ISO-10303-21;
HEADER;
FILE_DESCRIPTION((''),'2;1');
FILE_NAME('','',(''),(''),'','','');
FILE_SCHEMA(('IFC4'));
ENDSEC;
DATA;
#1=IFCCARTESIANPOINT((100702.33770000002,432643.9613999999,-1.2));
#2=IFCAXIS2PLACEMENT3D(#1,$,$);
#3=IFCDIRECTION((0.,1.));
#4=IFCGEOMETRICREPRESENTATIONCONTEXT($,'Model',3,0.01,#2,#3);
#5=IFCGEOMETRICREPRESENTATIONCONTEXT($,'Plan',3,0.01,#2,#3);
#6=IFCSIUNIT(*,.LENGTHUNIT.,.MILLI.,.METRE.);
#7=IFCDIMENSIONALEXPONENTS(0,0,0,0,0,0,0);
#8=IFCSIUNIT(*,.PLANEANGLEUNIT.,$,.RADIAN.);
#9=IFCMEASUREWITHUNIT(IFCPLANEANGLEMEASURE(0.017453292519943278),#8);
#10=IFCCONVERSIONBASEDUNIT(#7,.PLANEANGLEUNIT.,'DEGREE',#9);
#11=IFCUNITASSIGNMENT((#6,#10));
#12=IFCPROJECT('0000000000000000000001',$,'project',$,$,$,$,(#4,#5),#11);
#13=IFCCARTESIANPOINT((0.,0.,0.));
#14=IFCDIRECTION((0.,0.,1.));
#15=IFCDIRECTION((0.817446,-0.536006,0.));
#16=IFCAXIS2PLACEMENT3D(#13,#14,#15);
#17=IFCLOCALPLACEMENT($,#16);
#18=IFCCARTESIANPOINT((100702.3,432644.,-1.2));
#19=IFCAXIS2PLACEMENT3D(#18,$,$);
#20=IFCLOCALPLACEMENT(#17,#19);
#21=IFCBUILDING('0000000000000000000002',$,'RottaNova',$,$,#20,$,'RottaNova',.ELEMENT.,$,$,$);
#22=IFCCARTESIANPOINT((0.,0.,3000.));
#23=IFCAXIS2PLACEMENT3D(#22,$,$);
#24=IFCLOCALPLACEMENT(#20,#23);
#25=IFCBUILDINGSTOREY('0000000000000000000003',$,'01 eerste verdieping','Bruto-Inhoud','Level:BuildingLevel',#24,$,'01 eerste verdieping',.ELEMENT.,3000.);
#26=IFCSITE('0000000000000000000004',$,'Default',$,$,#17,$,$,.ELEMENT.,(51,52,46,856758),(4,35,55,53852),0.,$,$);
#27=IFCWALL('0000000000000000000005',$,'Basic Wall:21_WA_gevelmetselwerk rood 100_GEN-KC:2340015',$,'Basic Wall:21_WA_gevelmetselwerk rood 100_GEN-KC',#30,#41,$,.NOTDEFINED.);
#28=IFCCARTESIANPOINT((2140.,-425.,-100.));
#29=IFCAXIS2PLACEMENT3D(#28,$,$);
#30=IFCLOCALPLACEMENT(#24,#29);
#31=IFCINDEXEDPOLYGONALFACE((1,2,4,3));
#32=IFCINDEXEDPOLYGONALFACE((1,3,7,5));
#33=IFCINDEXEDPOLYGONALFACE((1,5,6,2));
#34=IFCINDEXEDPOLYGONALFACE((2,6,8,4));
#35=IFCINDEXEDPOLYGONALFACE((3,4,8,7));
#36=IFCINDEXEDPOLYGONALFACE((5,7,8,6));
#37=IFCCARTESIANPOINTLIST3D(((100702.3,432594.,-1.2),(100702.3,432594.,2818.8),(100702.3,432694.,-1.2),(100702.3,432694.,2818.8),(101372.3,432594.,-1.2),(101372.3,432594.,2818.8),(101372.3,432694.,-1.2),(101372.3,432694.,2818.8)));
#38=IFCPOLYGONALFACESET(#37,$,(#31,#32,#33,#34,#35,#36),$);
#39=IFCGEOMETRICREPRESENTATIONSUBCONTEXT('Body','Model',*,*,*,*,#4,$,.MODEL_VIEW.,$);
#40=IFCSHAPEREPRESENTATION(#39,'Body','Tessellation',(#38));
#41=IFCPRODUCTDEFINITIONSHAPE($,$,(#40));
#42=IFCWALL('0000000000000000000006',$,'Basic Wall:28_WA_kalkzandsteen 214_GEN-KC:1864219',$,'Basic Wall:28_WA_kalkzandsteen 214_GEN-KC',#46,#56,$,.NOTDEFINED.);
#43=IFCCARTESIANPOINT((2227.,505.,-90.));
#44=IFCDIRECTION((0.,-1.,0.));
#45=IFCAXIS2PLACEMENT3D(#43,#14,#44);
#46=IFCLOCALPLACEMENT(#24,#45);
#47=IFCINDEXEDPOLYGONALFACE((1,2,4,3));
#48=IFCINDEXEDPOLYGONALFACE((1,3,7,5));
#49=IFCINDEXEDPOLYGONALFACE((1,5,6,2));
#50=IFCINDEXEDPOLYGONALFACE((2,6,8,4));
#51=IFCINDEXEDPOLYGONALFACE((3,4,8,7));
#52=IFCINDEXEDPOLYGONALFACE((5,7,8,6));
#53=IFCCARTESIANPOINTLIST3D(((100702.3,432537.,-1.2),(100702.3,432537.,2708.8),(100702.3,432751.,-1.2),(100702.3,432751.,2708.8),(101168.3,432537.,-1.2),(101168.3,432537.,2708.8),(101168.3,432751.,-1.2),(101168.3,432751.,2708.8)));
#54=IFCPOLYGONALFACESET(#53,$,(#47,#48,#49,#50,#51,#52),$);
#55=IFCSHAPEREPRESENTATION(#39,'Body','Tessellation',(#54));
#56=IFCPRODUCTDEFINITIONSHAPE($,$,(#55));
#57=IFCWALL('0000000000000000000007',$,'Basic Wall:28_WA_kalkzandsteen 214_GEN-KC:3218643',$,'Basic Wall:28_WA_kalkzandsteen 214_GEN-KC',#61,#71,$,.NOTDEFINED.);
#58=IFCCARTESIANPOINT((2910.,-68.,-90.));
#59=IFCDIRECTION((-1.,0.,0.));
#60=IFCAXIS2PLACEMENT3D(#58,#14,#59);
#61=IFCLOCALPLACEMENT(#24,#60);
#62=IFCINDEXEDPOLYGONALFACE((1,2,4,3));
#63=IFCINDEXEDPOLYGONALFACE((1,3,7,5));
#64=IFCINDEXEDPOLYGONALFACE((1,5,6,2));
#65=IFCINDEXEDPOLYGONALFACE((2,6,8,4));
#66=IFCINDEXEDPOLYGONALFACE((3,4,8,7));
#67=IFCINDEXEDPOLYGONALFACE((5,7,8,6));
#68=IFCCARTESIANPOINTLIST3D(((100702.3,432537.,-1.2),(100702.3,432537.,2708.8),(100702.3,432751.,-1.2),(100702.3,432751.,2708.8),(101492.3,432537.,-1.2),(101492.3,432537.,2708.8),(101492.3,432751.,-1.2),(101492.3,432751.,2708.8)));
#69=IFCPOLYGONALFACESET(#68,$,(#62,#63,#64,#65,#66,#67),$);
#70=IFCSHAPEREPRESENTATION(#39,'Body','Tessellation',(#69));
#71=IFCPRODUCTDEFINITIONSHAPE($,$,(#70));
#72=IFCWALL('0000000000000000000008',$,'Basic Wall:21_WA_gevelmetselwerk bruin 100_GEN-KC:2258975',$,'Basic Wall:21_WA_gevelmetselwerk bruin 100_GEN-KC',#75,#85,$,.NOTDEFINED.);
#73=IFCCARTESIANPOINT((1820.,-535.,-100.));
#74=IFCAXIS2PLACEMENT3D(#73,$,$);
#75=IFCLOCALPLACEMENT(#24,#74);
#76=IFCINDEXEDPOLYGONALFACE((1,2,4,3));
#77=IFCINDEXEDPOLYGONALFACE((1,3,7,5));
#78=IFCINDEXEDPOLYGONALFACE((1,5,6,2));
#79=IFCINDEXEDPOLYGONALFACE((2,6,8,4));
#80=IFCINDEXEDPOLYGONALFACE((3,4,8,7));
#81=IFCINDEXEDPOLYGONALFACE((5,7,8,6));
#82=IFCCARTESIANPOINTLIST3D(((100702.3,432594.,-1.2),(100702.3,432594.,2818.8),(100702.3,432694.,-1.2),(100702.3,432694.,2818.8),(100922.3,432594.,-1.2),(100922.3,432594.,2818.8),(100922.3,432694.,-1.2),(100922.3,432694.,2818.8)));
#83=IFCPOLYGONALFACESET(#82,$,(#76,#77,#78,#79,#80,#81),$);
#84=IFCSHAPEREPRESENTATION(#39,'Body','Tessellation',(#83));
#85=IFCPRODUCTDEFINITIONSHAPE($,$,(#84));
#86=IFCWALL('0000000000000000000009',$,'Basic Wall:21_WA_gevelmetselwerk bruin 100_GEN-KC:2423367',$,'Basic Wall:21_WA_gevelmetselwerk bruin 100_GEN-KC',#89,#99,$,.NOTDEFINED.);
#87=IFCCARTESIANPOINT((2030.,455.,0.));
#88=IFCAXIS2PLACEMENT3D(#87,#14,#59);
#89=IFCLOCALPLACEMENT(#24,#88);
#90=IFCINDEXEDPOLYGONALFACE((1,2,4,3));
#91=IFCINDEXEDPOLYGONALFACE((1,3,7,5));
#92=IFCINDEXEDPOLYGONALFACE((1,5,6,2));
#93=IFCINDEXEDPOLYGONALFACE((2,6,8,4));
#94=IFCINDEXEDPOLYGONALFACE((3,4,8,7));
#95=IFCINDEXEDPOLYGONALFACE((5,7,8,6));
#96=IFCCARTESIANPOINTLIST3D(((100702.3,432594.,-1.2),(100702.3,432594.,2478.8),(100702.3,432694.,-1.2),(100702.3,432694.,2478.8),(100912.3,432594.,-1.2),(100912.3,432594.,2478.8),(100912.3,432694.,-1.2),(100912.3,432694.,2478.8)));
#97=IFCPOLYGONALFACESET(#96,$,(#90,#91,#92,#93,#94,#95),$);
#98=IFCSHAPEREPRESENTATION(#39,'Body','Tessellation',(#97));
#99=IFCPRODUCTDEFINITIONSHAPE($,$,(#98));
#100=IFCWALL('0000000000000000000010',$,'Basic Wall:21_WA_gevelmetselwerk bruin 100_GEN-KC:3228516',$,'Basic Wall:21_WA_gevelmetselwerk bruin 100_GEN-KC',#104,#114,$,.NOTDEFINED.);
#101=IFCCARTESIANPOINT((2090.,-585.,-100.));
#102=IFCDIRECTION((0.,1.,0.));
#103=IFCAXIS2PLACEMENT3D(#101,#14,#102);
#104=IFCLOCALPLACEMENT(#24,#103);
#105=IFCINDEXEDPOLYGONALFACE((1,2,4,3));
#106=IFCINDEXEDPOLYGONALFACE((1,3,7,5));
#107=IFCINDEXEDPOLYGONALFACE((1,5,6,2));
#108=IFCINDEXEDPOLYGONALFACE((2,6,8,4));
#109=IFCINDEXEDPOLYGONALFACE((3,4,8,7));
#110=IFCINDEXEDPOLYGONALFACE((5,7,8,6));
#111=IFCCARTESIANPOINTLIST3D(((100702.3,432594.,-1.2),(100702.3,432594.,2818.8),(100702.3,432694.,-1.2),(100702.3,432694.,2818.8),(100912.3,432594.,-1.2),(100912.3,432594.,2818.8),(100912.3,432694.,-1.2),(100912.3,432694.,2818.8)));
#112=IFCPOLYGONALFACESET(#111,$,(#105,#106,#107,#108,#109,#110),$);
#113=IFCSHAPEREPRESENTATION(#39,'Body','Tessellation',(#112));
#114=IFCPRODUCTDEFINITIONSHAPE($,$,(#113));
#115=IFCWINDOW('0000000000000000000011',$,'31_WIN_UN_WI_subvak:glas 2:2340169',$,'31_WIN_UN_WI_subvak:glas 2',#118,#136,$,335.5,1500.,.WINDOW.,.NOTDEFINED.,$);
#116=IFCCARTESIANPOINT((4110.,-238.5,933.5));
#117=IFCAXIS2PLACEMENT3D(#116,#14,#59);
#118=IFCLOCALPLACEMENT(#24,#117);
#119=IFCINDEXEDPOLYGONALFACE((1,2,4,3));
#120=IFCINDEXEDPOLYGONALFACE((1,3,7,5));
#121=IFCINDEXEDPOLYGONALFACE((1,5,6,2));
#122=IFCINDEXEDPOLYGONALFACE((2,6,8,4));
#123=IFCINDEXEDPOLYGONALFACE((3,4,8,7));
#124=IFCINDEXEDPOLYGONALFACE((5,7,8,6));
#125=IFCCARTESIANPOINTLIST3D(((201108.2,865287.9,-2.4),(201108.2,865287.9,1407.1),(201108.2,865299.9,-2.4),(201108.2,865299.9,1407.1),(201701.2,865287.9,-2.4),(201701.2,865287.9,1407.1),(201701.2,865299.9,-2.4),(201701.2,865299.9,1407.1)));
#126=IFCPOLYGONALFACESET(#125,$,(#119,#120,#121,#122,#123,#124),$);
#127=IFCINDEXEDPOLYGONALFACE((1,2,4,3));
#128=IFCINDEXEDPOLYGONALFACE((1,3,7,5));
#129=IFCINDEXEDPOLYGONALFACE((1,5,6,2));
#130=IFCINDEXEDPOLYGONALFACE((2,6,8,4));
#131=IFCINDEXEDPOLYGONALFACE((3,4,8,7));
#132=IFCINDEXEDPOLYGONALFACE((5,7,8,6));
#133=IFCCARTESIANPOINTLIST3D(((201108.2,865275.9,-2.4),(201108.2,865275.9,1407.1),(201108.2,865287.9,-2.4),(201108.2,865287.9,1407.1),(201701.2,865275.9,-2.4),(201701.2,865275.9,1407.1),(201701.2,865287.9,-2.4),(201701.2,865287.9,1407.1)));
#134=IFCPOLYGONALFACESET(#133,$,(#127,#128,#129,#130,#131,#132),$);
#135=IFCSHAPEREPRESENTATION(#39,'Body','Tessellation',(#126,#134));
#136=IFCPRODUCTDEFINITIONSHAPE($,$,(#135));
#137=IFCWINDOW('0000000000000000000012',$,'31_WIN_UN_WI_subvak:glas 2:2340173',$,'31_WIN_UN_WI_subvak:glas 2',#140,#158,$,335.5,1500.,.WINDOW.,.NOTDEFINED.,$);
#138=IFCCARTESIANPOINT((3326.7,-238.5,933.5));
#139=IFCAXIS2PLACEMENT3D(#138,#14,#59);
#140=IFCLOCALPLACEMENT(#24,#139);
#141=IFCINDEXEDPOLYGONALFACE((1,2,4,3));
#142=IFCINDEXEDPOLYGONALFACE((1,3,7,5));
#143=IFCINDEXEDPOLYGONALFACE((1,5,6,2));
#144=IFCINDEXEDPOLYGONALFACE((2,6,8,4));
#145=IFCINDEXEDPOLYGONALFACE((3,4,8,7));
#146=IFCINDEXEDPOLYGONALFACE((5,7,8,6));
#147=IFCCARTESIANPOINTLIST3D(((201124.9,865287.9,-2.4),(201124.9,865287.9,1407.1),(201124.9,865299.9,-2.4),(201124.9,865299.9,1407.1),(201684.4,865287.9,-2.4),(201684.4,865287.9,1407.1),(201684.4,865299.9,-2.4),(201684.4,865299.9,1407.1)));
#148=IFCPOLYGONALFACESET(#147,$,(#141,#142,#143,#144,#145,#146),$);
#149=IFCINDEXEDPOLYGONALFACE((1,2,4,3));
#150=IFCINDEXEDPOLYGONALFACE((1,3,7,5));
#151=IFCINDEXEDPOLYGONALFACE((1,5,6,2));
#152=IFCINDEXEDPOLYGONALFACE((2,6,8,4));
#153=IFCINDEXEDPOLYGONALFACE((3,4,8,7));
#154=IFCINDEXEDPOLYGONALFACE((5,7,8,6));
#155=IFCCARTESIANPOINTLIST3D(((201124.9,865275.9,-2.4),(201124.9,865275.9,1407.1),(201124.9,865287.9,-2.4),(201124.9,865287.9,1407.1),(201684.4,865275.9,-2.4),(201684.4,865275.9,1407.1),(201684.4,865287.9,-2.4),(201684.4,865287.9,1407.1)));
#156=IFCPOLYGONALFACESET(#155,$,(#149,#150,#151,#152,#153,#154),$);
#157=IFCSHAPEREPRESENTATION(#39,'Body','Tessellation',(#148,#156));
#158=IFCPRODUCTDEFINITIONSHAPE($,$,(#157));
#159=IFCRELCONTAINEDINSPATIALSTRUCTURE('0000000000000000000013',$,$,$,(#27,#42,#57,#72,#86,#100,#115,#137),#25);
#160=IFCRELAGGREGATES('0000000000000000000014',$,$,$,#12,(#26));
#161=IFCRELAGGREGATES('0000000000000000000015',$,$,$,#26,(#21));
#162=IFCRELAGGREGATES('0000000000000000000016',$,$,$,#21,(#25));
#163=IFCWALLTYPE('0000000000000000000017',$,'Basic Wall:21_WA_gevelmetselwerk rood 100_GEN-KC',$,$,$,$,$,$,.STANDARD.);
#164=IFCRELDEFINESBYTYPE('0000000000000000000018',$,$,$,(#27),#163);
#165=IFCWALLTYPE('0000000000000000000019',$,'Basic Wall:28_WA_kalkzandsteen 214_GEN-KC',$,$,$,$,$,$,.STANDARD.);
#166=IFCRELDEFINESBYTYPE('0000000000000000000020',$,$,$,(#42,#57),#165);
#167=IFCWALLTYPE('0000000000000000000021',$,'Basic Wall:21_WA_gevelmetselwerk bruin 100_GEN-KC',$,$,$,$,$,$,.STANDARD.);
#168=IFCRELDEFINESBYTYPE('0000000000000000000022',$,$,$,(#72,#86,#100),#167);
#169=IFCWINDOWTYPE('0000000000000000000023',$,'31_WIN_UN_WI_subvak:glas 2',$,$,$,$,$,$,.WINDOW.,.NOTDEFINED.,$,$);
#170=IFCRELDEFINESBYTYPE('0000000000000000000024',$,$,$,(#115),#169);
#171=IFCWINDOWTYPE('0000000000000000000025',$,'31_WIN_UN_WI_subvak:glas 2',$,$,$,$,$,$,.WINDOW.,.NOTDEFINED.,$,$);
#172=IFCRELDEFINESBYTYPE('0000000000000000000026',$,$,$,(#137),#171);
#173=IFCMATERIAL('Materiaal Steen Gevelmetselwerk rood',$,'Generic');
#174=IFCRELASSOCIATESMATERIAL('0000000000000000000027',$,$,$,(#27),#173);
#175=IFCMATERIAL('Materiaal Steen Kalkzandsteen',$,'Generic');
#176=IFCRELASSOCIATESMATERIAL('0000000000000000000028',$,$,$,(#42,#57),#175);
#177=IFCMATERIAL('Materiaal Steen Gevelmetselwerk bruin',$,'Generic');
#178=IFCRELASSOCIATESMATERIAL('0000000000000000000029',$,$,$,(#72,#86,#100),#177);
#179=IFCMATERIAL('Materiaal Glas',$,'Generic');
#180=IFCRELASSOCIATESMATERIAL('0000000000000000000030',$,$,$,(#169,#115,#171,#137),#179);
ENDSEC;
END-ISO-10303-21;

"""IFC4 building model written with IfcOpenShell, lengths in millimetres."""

from ifc_helpers import new_model, entity, si_unit, converted_unit, direction, frame, place, context, subcontext, project, spatial, indexed_curve, outline, extrude, source, transform, mapped, material, type_object, type_shapes, element, save


model = new_model("IFC4")

# Units and contexts
model_context = context("Model", 3, precision=0.01, world=frame((100702.33770000002, 432643.9613999999, -1.2)), true_north=direction((0.0, 1.0)))
plan_context = context("Plan", 3, precision=0.01, world=frame((100702.33770000002, 432643.9613999999, -1.2)), true_north=direction((0.0, 1.0)))
body_context = subcontext(model_context, "Body", "Model", "MODEL_VIEW")
ifc_project = project(units=[si_unit("LENGTHUNIT", "METRE", prefix="MILLI"), converted_unit("PLANEANGLEUNIT", "DEGREE", entity("IfcPlaneAngleMeasure", 0.017453292519943278), si_unit("PLANEANGLEUNIT", "RADIAN"), dimensions=[0, 0, 0, 0, 0, 0, 0])], contexts=[model_context, plan_context])

# Site, building, storey
site_placement = place(None, frame((0.0, 0.0, 0.0), z_axis=(0.0, 0.0, 1.0), x_axis=(0.817446, -0.536006, 0.0)))
site = spatial("IfcSite", under=ifc_project, at=site_placement, Name="Default", CompositionType="ELEMENT", RefLatitude=(51, 52, 46, 856758), RefLongitude=(4, 35, 55, 53852), RefElevation=0.0)
building_placement = place(site_placement, frame((100702.3, 432644.0, -1.2)))
building = spatial("IfcBuilding", under=site, at=building_placement, Name="RottaNova", LongName="RottaNova", CompositionType="ELEMENT")
storey_placement = place(building_placement, frame((0.0, 0.0, 3000.0)))
storey = spatial("IfcBuildingStorey", under=building, at=storey_placement, Name="01 eerste verdieping", Description="Bruto-Inhoud", ObjectType="Level:BuildingLevel", LongName="01 eerste verdieping", CompositionType="ELEMENT", Elevation=3000.0)

# Shared definitions
ifc_material_1 = material(Name="Materiaal Glas", Category="Generic")

# Walls
ifc_material_2 = material(Name="Materiaal Steen Gevelmetselwerk rood", Category="Generic")
wall_type_1 = type_object("IfcWallType", Name="Basic Wall:21_WA_gevelmetselwerk rood 100_GEN-KC", PredefinedType="STANDARD")
wall_1_placement = place(storey_placement, frame((2140.0, -425.0, -100.0)))
element("IfcWall", 1, at=wall_1_placement, inside=storey, type_object=wall_type_1, material=ifc_material_2, Name="Basic Wall:21_WA_gevelmetselwerk rood 100_GEN-KC:2340015", ObjectType="Basic Wall:21_WA_gevelmetselwerk rood 100_GEN-KC", PredefinedType="NOTDEFINED", context=body_context, shape_type="SweptSolid", body=[
    extrude(outline(indexed_curve([(670.0, 50.0), (0.0, 50.0), (0.0, -50.0), (670.0, -50.0), (670.0, 50.0)], self_intersect=False)), frame((100702.3, 432644.0, -1.2)), (0.0, 0.0, 1.0), 2820.0),
])
ifc_material_3 = material(Name="Materiaal Steen Kalkzandsteen", Category="Generic")
wall_type_2 = type_object("IfcWallType", Name="Basic Wall:28_WA_kalkzandsteen 214_GEN-KC", PredefinedType="STANDARD")
wall_2_placement = place(storey_placement, frame((2227.0, 505.0, -90.0), z_axis=(0.0, 0.0, 1.0), x_axis=(0.0, -1.0, 0.0)))
element("IfcWall", 2, at=wall_2_placement, inside=storey, type_object=wall_type_2, material=ifc_material_3, Name="Basic Wall:28_WA_kalkzandsteen 214_GEN-KC:1864219", ObjectType="Basic Wall:28_WA_kalkzandsteen 214_GEN-KC", PredefinedType="NOTDEFINED", context=body_context, shape_type="SweptSolid", body=[
    extrude(outline(indexed_curve([(466.0, 107.0), (0.0, 107.0), (0.0, -107.0), (466.0, -107.0), (466.0, 107.0)], self_intersect=False)), frame((100702.3, 432644.0, -1.2)), (0.0, 0.0, 1.0), 2710.0),
])
wall_3_placement = place(storey_placement, frame((2910.0, -68.0, -90.0), z_axis=(0.0, 0.0, 1.0), x_axis=(-1.0, 0.0, 0.0)))
element("IfcWall", 3, at=wall_3_placement, inside=storey, type_object=wall_type_2, material=ifc_material_3, Name="Basic Wall:28_WA_kalkzandsteen 214_GEN-KC:3218643", ObjectType="Basic Wall:28_WA_kalkzandsteen 214_GEN-KC", PredefinedType="NOTDEFINED", context=body_context, shape_type="SweptSolid", body=[
    extrude(outline(indexed_curve([(790.0, 107.0), (0.0, 107.0), (0.0, -107.0), (790.0, -107.0), (790.0, 107.0)], self_intersect=False)), frame((100702.3, 432644.0, -1.2)), (0.0, 0.0, 1.0), 2710.0),
])
ifc_material_4 = material(Name="Materiaal Steen Gevelmetselwerk bruin", Category="Generic")
wall_type_3 = type_object("IfcWallType", Name="Basic Wall:21_WA_gevelmetselwerk bruin 100_GEN-KC", PredefinedType="STANDARD")
wall_4_placement = place(storey_placement, frame((1820.0, -535.0, -100.0)))
element("IfcWall", 4, at=wall_4_placement, inside=storey, type_object=wall_type_3, material=ifc_material_4, Name="Basic Wall:21_WA_gevelmetselwerk bruin 100_GEN-KC:2258975", ObjectType="Basic Wall:21_WA_gevelmetselwerk bruin 100_GEN-KC", PredefinedType="NOTDEFINED", context=body_context, shape_type="SweptSolid", body=[
    extrude(outline(indexed_curve([(220.0, 50.0), (0.0, 50.0), (0.0, -50.0), (220.0, -50.0), (220.0, 50.0)], self_intersect=False)), frame((100702.3, 432644.0, -1.2)), (0.0, 0.0, 1.0), 2820.0),
])
wall_5_placement = place(storey_placement, frame((2030.0, 455.0, 0.0), z_axis=(0.0, 0.0, 1.0), x_axis=(-1.0, 0.0, 0.0)))
element("IfcWall", 5, at=wall_5_placement, inside=storey, type_object=wall_type_3, material=ifc_material_4, Name="Basic Wall:21_WA_gevelmetselwerk bruin 100_GEN-KC:2423367", ObjectType="Basic Wall:21_WA_gevelmetselwerk bruin 100_GEN-KC", PredefinedType="NOTDEFINED", context=body_context, shape_type="SweptSolid", body=[
    extrude(outline(indexed_curve([(210.0, 50.0), (0.0, 50.0), (0.0, -50.0), (210.0, -50.0), (210.0, 50.0)], self_intersect=False)), frame((100702.3, 432644.0, -1.2)), (0.0, 0.0, 1.0), 2480.0),
])
wall_6_placement = place(storey_placement, frame((2090.0, -585.0, -100.0), z_axis=(0.0, 0.0, 1.0), x_axis=(0.0, 1.0, 0.0)))
element("IfcWall", 6, at=wall_6_placement, inside=storey, type_object=wall_type_3, material=ifc_material_4, Name="Basic Wall:21_WA_gevelmetselwerk bruin 100_GEN-KC:3228516", ObjectType="Basic Wall:21_WA_gevelmetselwerk bruin 100_GEN-KC", PredefinedType="NOTDEFINED", context=body_context, shape_type="SweptSolid", body=[
    extrude(outline(indexed_curve([(210.0, 50.0), (0.0, 50.0), (0.0, -50.0), (210.0, -50.0), (210.0, 50.0)], self_intersect=False)), frame((100702.3, 432644.0, -1.2)), (0.0, 0.0, 1.0), 2820.0),
])

# Windows
window_type_1 = type_object("IfcWindowType", Name="31_WIN_UN_WI_subvak:glas 2", PartitioningType="NOTDEFINED", PredefinedType="WINDOW", material=ifc_material_1)
shared_shape_1 = source(frame((100702.3, 432644.0, -1.2)), body_context, "Body", "SweptSolid", [
    extrude(outline(indexed_curve([(-6.0, -296.5), (6.0, -296.5), (6.0, 296.5), (-6.0, 296.5), (-6.0, -296.5)], self_intersect=False)), frame((0.0, 6.0, 0.0), z_axis=(0.0, 0.0, 1.0), x_axis=(0.0, -1.0, 0.0)), (0.0, 0.0, 1.0), 1409.5),
    extrude(outline(indexed_curve([(-6.0, -296.5), (6.0, -296.5), (6.0, 296.5), (-6.0, 296.5), (-6.0, -296.5)], self_intersect=False)), frame((0.0, -6.0, 0.0), z_axis=(0.0, 0.0, 1.0), x_axis=(0.0, -1.0, 0.0)), (0.0, 0.0, 1.0), 1409.5),
])
type_shapes(window_type_1, [shared_shape_1])
window_1_placement = place(storey_placement, frame((4110.0, -238.5, 933.5), z_axis=(0.0, 0.0, 1.0), x_axis=(-1.0, 0.0, 0.0)))
element("IfcWindow", 7, at=window_1_placement, inside=storey, type_object=window_type_1, material=ifc_material_1, Name="31_WIN_UN_WI_subvak:glas 2:2340169", ObjectType="31_WIN_UN_WI_subvak:glas 2", OverallHeight=335.5, OverallWidth=1500.0, PartitioningType="NOTDEFINED", PredefinedType="WINDOW", context=body_context, shape_type="MappedRepresentation", body=[
    mapped(shared_shape_1, transform((100702.3, 432644.0, -1.2), scale=1.0)),
])
window_type_2 = type_object("IfcWindowType", Name="31_WIN_UN_WI_subvak:glas 2", PartitioningType="NOTDEFINED", PredefinedType="WINDOW", material=ifc_material_1)
shared_shape_2 = source(frame((100702.3, 432644.0, -1.2)), body_context, "Body", "SweptSolid", [
    extrude(outline(indexed_curve([(-6.0, -279.8), (6.0, -279.8), (6.0, 279.8), (-6.0, 279.8), (-6.0, -279.8)], self_intersect=False)), frame((0.0, 6.0, 0.0), z_axis=(0.0, 0.0, 1.0), x_axis=(0.0, -1.0, 0.0)), (0.0, 0.0, 1.0), 1409.5),
    extrude(outline(indexed_curve([(-6.0, -279.8), (6.0, -279.8), (6.0, 279.8), (-6.0, 279.8), (-6.0, -279.8)], self_intersect=False)), frame((0.0, -6.0, 0.0), z_axis=(0.0, 0.0, 1.0), x_axis=(0.0, -1.0, 0.0)), (0.0, 0.0, 1.0), 1409.5),
])
type_shapes(window_type_2, [shared_shape_2])
window_2_placement = place(storey_placement, frame((3326.7, -238.5, 933.5), z_axis=(0.0, 0.0, 1.0), x_axis=(-1.0, 0.0, 0.0)))
element("IfcWindow", 8, at=window_2_placement, inside=storey, type_object=window_type_2, material=ifc_material_1, Name="31_WIN_UN_WI_subvak:glas 2:2340173", ObjectType="31_WIN_UN_WI_subvak:glas 2", OverallHeight=335.5, OverallWidth=1500.0, PartitioningType="NOTDEFINED", PredefinedType="WINDOW", context=body_context, shape_type="MappedRepresentation", body=[
    mapped(shared_shape_2, transform((100702.3, 432644.0, -1.2), scale=1.0)),
])

save(model, "model.ifc")
